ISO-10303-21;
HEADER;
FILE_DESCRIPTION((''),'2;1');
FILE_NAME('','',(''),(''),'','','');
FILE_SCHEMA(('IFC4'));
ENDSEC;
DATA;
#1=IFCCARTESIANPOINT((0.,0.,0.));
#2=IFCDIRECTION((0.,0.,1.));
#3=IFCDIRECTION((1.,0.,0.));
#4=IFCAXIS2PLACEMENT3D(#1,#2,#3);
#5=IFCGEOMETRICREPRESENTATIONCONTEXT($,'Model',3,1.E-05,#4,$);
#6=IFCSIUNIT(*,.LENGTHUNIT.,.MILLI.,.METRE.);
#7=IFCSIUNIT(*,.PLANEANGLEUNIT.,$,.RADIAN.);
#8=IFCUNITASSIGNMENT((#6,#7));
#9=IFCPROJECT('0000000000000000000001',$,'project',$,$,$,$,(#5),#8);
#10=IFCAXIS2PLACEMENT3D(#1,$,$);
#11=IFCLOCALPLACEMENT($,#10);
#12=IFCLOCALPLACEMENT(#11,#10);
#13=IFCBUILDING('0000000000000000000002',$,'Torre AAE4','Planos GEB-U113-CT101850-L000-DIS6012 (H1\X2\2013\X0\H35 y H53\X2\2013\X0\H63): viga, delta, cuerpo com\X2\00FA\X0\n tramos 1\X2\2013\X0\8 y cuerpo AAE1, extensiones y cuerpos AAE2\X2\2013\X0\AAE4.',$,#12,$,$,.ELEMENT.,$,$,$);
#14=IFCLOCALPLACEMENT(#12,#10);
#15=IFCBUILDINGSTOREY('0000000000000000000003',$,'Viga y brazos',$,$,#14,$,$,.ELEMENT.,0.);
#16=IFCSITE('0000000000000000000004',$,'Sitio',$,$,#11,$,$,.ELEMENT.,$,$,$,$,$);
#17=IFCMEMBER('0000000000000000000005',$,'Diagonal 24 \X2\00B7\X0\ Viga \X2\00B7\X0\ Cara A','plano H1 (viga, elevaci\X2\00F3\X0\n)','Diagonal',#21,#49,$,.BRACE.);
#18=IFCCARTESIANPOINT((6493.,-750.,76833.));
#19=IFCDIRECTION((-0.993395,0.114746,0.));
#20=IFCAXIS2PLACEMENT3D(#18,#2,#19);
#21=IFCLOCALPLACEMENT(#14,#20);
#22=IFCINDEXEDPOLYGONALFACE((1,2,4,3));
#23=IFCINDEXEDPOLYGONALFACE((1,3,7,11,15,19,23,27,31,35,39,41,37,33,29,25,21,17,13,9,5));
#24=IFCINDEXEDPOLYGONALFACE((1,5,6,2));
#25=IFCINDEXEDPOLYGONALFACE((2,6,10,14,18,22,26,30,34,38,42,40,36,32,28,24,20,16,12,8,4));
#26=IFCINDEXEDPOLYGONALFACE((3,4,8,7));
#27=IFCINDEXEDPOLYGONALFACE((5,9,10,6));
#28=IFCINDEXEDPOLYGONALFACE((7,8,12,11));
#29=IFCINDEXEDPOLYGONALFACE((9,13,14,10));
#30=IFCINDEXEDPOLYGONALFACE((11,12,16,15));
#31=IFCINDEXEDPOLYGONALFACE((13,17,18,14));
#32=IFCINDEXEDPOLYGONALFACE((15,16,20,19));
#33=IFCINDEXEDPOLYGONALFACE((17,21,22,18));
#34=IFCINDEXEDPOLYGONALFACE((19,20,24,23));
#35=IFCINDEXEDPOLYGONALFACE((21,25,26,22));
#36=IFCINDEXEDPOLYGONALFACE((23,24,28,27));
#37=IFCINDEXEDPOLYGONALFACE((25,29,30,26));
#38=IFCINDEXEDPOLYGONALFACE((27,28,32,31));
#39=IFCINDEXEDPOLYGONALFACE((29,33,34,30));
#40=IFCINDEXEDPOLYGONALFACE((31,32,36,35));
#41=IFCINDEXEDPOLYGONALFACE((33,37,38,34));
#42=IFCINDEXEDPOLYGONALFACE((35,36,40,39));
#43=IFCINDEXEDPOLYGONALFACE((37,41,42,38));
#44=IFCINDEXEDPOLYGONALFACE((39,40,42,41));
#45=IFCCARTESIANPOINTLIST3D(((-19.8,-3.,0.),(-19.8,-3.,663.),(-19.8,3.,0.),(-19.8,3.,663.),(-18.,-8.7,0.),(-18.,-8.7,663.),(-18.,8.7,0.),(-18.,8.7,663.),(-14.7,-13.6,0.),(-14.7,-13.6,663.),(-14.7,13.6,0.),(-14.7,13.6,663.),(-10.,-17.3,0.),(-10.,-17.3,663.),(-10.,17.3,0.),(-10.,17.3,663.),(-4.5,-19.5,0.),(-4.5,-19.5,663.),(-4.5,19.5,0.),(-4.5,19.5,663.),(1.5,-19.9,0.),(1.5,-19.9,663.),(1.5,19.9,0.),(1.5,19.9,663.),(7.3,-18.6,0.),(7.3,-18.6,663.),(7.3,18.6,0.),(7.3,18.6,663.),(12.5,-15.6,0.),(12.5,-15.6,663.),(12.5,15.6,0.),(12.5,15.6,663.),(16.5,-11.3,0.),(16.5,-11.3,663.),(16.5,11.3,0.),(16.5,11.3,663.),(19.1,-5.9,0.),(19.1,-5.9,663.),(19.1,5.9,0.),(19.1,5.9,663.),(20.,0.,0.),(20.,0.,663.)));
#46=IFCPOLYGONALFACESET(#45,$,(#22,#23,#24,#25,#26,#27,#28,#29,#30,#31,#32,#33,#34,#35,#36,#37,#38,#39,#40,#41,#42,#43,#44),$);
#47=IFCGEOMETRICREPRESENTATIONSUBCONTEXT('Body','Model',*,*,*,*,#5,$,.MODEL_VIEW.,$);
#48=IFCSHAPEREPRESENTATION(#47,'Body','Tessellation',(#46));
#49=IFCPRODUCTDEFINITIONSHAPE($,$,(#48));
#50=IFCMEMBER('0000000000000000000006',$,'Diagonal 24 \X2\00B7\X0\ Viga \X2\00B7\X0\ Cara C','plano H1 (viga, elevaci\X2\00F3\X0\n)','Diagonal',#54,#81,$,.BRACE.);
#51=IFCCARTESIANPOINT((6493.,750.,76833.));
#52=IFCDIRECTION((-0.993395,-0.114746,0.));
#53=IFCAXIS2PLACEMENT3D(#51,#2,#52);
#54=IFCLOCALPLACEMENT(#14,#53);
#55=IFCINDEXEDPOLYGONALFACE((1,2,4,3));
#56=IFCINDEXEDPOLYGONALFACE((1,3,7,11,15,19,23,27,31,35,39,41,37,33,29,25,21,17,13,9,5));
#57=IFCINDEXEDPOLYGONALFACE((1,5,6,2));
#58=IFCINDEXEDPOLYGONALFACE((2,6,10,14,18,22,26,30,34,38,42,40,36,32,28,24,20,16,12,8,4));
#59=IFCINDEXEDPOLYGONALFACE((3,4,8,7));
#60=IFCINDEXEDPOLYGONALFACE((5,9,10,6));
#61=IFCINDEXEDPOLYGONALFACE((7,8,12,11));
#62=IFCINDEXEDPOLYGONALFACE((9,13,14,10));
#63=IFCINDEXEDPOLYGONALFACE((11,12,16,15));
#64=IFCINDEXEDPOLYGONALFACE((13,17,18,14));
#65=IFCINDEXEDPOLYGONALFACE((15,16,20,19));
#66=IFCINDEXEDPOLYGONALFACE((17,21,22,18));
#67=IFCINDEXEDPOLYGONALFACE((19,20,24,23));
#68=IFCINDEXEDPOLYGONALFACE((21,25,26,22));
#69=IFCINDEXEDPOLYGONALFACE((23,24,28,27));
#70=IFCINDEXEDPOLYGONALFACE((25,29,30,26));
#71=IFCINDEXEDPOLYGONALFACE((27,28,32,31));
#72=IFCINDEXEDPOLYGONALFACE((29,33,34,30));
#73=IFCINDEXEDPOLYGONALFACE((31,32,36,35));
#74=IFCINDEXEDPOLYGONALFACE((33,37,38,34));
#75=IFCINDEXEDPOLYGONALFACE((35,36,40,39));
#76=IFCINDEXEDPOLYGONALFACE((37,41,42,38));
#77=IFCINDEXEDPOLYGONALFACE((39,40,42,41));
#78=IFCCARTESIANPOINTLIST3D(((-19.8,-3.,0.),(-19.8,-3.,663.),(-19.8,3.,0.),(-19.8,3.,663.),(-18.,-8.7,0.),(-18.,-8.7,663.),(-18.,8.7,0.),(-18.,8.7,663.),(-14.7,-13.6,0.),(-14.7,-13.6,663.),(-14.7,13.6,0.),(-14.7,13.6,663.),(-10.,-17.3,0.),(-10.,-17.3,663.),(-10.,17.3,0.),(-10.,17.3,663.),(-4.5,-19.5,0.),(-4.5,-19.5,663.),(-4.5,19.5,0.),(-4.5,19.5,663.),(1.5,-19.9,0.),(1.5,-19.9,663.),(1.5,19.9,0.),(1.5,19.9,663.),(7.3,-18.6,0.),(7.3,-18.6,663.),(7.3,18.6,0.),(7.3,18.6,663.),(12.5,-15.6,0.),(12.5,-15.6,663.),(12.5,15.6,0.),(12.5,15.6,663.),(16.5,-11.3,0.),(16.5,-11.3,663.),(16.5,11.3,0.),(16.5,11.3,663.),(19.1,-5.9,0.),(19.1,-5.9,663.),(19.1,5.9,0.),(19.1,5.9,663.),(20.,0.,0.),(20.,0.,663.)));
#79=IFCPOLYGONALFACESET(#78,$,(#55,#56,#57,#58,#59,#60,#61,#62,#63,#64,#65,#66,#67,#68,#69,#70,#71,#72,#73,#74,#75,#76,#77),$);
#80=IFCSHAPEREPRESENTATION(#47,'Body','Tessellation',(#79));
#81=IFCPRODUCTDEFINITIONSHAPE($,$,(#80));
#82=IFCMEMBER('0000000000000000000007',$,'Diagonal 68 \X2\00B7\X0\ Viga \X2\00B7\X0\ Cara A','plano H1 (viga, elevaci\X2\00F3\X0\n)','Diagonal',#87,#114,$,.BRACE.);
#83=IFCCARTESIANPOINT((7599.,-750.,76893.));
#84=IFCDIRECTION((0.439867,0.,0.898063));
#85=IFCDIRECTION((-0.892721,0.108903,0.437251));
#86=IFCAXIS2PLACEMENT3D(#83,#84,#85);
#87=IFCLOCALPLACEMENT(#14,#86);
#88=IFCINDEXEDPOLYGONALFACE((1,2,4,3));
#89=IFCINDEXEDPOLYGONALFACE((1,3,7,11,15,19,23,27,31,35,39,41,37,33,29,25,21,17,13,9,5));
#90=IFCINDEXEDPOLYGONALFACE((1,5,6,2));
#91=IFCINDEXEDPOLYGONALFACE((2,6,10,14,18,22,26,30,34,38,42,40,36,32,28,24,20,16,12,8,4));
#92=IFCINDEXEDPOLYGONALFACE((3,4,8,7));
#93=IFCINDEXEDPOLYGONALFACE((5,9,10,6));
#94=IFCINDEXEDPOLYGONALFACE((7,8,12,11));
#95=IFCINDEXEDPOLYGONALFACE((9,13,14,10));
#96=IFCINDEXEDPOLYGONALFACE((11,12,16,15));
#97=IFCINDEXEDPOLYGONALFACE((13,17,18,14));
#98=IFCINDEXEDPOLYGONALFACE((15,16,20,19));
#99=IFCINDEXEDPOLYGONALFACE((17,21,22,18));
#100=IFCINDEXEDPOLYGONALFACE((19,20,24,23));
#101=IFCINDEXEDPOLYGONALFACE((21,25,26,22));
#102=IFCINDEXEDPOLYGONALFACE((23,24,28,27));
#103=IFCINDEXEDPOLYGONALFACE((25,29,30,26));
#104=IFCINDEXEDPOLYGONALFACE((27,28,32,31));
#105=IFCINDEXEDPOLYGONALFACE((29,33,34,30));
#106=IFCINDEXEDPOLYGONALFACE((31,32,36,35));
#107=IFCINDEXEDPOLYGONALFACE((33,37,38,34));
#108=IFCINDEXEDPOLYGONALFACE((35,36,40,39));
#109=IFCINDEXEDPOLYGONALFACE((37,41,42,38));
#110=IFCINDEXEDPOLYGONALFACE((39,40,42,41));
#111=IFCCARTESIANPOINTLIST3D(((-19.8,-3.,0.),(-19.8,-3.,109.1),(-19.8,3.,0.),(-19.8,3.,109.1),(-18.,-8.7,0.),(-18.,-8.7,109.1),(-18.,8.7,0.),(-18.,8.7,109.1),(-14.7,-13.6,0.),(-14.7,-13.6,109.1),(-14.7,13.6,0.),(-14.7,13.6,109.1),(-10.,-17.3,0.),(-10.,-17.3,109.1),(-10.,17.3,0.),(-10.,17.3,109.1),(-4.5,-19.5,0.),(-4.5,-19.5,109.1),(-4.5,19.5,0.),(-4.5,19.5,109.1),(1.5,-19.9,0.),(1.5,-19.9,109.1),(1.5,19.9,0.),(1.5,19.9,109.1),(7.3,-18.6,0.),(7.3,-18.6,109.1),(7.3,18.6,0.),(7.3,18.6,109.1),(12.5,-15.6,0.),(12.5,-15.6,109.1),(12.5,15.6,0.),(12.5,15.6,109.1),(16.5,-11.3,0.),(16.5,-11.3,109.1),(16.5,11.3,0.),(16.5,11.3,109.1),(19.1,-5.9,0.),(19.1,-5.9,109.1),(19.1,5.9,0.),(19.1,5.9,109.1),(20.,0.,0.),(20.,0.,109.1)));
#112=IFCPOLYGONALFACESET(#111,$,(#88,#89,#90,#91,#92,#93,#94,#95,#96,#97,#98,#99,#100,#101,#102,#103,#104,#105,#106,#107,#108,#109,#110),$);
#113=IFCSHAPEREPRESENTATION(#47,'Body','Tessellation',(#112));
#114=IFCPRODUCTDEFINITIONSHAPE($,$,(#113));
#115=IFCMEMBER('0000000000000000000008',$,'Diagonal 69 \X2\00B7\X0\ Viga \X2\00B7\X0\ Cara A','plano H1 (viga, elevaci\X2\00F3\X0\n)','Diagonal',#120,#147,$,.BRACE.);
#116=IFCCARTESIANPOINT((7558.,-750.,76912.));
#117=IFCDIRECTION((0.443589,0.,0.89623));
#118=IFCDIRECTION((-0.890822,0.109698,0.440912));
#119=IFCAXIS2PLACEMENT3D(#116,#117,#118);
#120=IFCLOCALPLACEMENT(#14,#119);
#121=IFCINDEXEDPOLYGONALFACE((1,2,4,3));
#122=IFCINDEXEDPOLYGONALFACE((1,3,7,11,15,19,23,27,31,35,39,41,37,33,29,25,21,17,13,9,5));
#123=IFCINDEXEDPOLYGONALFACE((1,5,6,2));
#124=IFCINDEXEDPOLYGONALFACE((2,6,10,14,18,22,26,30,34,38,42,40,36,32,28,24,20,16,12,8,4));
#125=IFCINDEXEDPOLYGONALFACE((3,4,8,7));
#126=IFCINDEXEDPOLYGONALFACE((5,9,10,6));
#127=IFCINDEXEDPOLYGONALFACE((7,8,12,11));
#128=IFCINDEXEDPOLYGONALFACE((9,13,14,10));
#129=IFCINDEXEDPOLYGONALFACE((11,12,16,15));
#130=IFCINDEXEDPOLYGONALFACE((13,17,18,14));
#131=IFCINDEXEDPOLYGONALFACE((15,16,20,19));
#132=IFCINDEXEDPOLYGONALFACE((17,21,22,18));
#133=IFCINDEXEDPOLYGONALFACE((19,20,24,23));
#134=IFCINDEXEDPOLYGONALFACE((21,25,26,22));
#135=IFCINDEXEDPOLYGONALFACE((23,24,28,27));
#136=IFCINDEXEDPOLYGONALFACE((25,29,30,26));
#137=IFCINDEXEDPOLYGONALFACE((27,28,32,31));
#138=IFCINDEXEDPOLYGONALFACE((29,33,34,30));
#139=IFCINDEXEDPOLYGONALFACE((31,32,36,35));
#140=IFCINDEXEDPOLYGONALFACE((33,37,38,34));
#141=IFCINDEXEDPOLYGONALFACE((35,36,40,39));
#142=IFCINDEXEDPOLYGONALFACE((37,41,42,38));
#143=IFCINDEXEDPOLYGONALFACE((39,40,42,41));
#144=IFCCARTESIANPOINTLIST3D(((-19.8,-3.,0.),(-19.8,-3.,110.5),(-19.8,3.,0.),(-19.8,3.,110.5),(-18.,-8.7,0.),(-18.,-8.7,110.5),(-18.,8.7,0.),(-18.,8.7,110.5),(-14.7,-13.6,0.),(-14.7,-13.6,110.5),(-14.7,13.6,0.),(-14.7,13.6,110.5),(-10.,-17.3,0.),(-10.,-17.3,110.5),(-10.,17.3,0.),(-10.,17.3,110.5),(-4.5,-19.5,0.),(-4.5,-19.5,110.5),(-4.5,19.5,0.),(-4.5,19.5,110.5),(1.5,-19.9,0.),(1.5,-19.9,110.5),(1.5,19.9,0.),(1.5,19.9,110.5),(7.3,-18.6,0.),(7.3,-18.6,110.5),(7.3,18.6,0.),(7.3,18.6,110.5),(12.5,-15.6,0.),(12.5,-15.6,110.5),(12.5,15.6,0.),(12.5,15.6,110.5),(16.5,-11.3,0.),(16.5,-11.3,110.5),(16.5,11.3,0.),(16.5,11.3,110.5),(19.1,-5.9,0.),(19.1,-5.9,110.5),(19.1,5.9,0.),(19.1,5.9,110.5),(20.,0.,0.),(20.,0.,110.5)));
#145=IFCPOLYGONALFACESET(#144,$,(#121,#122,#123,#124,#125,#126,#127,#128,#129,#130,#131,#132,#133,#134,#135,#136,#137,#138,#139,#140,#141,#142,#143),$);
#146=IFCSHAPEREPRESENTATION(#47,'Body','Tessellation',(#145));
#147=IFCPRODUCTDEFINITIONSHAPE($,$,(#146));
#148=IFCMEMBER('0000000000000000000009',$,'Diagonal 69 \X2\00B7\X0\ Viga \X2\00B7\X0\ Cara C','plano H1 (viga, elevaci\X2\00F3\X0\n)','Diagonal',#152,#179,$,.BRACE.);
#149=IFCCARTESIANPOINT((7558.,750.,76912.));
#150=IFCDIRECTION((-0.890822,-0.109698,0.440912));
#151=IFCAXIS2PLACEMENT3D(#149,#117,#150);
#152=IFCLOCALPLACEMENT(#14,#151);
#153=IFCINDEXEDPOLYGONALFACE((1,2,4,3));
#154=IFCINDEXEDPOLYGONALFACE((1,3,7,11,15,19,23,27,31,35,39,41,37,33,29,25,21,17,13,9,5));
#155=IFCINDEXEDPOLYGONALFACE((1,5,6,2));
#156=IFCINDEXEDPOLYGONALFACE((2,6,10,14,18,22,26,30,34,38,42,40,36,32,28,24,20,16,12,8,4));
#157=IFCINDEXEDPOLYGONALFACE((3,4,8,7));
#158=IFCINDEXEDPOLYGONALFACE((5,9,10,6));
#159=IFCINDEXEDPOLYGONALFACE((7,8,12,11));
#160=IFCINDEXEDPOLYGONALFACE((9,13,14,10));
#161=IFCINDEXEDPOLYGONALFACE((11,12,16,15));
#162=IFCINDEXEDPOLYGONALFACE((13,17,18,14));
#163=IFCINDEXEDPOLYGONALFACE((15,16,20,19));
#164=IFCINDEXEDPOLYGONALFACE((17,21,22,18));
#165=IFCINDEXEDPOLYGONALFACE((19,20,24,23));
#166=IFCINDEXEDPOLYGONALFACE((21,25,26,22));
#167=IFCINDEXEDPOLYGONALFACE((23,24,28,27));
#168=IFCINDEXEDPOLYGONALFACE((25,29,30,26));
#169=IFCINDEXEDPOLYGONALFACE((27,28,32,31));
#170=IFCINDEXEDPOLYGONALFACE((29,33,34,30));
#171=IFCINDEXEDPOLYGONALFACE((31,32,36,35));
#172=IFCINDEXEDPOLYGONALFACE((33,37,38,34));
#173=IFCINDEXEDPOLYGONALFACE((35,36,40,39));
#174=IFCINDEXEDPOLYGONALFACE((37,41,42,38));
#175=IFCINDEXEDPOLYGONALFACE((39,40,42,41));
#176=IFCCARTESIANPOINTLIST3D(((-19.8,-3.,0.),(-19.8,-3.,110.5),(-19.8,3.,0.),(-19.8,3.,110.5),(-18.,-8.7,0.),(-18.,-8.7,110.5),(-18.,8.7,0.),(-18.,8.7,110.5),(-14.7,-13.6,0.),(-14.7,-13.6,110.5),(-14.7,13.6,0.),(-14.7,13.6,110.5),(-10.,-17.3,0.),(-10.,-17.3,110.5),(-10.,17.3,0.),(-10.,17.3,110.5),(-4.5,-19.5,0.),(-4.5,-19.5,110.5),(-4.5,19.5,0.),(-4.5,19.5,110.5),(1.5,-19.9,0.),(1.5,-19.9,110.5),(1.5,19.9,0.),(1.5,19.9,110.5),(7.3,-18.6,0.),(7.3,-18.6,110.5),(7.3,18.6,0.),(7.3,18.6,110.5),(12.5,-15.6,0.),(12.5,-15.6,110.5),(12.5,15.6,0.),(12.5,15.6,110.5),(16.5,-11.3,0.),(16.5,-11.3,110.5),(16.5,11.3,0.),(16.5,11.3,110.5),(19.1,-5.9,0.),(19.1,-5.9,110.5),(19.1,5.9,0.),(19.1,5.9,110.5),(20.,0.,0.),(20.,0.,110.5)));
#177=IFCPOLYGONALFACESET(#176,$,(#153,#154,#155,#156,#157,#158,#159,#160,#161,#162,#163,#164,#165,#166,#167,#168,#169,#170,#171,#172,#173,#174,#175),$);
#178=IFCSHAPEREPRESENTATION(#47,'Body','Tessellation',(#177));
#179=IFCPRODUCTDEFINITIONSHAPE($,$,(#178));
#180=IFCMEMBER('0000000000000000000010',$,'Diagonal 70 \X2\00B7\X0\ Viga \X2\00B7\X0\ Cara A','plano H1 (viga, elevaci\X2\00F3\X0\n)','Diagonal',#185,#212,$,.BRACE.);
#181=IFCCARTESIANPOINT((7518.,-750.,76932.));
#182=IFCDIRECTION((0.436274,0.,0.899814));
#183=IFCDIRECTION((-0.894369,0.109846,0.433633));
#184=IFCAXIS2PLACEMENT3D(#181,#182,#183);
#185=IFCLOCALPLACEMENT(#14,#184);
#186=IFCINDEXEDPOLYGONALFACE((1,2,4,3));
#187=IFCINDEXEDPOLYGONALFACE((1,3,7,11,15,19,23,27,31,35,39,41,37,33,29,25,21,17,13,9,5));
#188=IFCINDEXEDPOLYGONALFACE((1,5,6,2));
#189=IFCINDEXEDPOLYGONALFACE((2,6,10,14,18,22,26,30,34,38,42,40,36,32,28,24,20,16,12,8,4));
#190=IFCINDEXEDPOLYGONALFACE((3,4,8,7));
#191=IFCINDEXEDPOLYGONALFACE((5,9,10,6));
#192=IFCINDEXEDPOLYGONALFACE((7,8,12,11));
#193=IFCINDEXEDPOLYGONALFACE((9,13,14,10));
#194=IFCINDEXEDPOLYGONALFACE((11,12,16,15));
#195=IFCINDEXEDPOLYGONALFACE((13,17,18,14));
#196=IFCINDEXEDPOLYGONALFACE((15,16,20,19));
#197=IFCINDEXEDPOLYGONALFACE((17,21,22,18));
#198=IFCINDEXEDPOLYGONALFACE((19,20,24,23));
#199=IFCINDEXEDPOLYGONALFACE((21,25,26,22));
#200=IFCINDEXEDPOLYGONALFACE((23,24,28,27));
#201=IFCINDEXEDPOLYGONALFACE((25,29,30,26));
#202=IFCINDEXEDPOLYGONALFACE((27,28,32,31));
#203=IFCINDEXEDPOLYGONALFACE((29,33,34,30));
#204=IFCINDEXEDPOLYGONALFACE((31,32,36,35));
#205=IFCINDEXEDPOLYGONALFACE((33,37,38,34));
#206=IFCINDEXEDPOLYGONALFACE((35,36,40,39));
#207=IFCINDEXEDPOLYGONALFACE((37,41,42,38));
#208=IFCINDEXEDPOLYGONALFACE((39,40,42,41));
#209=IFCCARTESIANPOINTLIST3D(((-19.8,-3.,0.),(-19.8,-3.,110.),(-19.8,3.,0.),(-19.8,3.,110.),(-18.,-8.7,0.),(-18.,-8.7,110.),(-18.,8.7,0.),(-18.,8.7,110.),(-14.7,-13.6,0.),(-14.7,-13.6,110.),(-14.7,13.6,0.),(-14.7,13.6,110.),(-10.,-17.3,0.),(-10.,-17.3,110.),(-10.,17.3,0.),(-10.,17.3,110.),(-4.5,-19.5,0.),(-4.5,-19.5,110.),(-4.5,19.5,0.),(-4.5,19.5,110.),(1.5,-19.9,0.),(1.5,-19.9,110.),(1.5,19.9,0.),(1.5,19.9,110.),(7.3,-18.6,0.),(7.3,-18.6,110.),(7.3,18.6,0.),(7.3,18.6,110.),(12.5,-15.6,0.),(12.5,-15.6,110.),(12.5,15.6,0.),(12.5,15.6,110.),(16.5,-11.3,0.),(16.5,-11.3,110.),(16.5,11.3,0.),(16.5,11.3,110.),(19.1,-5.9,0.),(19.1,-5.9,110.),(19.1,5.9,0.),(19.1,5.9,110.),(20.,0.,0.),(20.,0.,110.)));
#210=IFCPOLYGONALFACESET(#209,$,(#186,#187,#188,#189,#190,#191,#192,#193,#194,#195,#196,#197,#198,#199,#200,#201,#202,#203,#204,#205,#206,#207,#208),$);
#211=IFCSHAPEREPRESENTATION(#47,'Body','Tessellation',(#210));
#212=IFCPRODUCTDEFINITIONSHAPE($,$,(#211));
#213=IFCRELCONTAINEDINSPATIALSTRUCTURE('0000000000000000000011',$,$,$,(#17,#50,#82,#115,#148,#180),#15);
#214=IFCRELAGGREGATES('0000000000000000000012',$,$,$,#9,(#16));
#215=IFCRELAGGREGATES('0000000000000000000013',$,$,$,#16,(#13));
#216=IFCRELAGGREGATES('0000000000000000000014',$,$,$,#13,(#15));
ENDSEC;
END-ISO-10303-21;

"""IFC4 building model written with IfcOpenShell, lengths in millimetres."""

from ifc_helpers import new_model, si_unit, frame, origin, origin_with_axes, place, context, subcontext, project, spatial, circle, extrude, element, save


model = new_model("IFC4")

# Units and contexts
model_context = context("Model", 3, precision=1e-05, world=origin_with_axes())
body_context = subcontext(model_context, "Body", "Model", "MODEL_VIEW")
ifc_project = project(units=[si_unit("LENGTHUNIT", "METRE", prefix="MILLI"), si_unit("PLANEANGLEUNIT", "RADIAN")], contexts=[model_context])

# Site, building, storey
site_placement = place(None, origin())
site = spatial("IfcSite", under=ifc_project, at=site_placement, Name="Sitio", CompositionType="ELEMENT")
building_placement = place(site_placement, origin())
building = spatial("IfcBuilding", under=site, at=building_placement, Name="Torre AAE4", Description="Planos GEB-U113-CT101850-L000-DIS6012 (H1–H35 y H53–H63): viga, delta, cuerpo común tramos 1–8 y cuerpo AAE1, extensiones y cuerpos AAE2–AAE4.", CompositionType="ELEMENT")
storey_placement = place(building_placement, origin())
storey = spatial("IfcBuildingStorey", under=building, at=storey_placement, Name="Viga y brazos", CompositionType="ELEMENT", Elevation=0.0)

# Members
for number, where, z_axis, x_axis, name in (
    (1, (6493.0, -750.0, 76833.0), (0.0, 0.0, 1.0), (-0.993395, 0.114746, 0.0), "Diagonal 24 · Viga · Cara A"),
    (2, (6493.0, 750.0, 76833.0), (0.0, 0.0, 1.0), (-0.993395, -0.114746, 0.0), "Diagonal 24 · Viga · Cara C"),
):
    element("IfcMember", number, at=place(storey_placement, frame(where, z_axis=z_axis, x_axis=x_axis)), inside=storey, Name=name, Description="plano H1 (viga, elevación)", ObjectType="Diagonal", PredefinedType="BRACE", context=body_context, shape_type="SweptSolid", body=[
        extrude(circle(Radius=20.0), None, (0.0, 0.0, 1.0), 663.0),
    ])
member_1_placement = place(storey_placement, frame((7599.0, -750.0, 76893.0), z_axis=(0.439867, 0.0, 0.898063), x_axis=(-0.892721, 0.108903, 0.437251)))
element("IfcMember", 3, at=member_1_placement, inside=storey, Name="Diagonal 68 · Viga · Cara A", Description="plano H1 (viga, elevación)", ObjectType="Diagonal", PredefinedType="BRACE", context=body_context, shape_type="SweptSolid", body=[
    extrude(circle(Radius=20.0), None, (0.0, 0.0, 1.0), 109.1),
])
for number, where, z_axis, x_axis, name in (
    (4, (7558.0, -750.0, 76912.0), (0.443589, 0.0, 0.89623), (-0.890822, 0.109698, 0.440912), "Diagonal 69 · Viga · Cara A"),
    (5, (7558.0, 750.0, 76912.0), (0.443589, 0.0, 0.89623), (-0.890822, -0.109698, 0.440912), "Diagonal 69 · Viga · Cara C"),
):
    element("IfcMember", number, at=place(storey_placement, frame(where, z_axis=z_axis, x_axis=x_axis)), inside=storey, Name=name, Description="plano H1 (viga, elevación)", ObjectType="Diagonal", PredefinedType="BRACE", context=body_context, shape_type="SweptSolid", body=[
        extrude(circle(Radius=20.0), None, (0.0, 0.0, 1.0), 110.5),
    ])
for number, where, z_axis, x_axis, name in (
    (6, (7518.0, -750.0, 76932.0), (0.436274, 0.0, 0.899814), (-0.894369, 0.109846, 0.433633), "Diagonal 70 · Viga · Cara A"),
):
    element("IfcMember", number, at=place(storey_placement, frame(where, z_axis=z_axis, x_axis=x_axis)), inside=storey, Name=name, Description="plano H1 (viga, elevación)", ObjectType="Diagonal", PredefinedType="BRACE", context=body_context, shape_type="SweptSolid", body=[
        extrude(circle(Radius=20.0), None, (0.0, 0.0, 1.0), 110.0),
    ])

save(model, "model.ifc")
